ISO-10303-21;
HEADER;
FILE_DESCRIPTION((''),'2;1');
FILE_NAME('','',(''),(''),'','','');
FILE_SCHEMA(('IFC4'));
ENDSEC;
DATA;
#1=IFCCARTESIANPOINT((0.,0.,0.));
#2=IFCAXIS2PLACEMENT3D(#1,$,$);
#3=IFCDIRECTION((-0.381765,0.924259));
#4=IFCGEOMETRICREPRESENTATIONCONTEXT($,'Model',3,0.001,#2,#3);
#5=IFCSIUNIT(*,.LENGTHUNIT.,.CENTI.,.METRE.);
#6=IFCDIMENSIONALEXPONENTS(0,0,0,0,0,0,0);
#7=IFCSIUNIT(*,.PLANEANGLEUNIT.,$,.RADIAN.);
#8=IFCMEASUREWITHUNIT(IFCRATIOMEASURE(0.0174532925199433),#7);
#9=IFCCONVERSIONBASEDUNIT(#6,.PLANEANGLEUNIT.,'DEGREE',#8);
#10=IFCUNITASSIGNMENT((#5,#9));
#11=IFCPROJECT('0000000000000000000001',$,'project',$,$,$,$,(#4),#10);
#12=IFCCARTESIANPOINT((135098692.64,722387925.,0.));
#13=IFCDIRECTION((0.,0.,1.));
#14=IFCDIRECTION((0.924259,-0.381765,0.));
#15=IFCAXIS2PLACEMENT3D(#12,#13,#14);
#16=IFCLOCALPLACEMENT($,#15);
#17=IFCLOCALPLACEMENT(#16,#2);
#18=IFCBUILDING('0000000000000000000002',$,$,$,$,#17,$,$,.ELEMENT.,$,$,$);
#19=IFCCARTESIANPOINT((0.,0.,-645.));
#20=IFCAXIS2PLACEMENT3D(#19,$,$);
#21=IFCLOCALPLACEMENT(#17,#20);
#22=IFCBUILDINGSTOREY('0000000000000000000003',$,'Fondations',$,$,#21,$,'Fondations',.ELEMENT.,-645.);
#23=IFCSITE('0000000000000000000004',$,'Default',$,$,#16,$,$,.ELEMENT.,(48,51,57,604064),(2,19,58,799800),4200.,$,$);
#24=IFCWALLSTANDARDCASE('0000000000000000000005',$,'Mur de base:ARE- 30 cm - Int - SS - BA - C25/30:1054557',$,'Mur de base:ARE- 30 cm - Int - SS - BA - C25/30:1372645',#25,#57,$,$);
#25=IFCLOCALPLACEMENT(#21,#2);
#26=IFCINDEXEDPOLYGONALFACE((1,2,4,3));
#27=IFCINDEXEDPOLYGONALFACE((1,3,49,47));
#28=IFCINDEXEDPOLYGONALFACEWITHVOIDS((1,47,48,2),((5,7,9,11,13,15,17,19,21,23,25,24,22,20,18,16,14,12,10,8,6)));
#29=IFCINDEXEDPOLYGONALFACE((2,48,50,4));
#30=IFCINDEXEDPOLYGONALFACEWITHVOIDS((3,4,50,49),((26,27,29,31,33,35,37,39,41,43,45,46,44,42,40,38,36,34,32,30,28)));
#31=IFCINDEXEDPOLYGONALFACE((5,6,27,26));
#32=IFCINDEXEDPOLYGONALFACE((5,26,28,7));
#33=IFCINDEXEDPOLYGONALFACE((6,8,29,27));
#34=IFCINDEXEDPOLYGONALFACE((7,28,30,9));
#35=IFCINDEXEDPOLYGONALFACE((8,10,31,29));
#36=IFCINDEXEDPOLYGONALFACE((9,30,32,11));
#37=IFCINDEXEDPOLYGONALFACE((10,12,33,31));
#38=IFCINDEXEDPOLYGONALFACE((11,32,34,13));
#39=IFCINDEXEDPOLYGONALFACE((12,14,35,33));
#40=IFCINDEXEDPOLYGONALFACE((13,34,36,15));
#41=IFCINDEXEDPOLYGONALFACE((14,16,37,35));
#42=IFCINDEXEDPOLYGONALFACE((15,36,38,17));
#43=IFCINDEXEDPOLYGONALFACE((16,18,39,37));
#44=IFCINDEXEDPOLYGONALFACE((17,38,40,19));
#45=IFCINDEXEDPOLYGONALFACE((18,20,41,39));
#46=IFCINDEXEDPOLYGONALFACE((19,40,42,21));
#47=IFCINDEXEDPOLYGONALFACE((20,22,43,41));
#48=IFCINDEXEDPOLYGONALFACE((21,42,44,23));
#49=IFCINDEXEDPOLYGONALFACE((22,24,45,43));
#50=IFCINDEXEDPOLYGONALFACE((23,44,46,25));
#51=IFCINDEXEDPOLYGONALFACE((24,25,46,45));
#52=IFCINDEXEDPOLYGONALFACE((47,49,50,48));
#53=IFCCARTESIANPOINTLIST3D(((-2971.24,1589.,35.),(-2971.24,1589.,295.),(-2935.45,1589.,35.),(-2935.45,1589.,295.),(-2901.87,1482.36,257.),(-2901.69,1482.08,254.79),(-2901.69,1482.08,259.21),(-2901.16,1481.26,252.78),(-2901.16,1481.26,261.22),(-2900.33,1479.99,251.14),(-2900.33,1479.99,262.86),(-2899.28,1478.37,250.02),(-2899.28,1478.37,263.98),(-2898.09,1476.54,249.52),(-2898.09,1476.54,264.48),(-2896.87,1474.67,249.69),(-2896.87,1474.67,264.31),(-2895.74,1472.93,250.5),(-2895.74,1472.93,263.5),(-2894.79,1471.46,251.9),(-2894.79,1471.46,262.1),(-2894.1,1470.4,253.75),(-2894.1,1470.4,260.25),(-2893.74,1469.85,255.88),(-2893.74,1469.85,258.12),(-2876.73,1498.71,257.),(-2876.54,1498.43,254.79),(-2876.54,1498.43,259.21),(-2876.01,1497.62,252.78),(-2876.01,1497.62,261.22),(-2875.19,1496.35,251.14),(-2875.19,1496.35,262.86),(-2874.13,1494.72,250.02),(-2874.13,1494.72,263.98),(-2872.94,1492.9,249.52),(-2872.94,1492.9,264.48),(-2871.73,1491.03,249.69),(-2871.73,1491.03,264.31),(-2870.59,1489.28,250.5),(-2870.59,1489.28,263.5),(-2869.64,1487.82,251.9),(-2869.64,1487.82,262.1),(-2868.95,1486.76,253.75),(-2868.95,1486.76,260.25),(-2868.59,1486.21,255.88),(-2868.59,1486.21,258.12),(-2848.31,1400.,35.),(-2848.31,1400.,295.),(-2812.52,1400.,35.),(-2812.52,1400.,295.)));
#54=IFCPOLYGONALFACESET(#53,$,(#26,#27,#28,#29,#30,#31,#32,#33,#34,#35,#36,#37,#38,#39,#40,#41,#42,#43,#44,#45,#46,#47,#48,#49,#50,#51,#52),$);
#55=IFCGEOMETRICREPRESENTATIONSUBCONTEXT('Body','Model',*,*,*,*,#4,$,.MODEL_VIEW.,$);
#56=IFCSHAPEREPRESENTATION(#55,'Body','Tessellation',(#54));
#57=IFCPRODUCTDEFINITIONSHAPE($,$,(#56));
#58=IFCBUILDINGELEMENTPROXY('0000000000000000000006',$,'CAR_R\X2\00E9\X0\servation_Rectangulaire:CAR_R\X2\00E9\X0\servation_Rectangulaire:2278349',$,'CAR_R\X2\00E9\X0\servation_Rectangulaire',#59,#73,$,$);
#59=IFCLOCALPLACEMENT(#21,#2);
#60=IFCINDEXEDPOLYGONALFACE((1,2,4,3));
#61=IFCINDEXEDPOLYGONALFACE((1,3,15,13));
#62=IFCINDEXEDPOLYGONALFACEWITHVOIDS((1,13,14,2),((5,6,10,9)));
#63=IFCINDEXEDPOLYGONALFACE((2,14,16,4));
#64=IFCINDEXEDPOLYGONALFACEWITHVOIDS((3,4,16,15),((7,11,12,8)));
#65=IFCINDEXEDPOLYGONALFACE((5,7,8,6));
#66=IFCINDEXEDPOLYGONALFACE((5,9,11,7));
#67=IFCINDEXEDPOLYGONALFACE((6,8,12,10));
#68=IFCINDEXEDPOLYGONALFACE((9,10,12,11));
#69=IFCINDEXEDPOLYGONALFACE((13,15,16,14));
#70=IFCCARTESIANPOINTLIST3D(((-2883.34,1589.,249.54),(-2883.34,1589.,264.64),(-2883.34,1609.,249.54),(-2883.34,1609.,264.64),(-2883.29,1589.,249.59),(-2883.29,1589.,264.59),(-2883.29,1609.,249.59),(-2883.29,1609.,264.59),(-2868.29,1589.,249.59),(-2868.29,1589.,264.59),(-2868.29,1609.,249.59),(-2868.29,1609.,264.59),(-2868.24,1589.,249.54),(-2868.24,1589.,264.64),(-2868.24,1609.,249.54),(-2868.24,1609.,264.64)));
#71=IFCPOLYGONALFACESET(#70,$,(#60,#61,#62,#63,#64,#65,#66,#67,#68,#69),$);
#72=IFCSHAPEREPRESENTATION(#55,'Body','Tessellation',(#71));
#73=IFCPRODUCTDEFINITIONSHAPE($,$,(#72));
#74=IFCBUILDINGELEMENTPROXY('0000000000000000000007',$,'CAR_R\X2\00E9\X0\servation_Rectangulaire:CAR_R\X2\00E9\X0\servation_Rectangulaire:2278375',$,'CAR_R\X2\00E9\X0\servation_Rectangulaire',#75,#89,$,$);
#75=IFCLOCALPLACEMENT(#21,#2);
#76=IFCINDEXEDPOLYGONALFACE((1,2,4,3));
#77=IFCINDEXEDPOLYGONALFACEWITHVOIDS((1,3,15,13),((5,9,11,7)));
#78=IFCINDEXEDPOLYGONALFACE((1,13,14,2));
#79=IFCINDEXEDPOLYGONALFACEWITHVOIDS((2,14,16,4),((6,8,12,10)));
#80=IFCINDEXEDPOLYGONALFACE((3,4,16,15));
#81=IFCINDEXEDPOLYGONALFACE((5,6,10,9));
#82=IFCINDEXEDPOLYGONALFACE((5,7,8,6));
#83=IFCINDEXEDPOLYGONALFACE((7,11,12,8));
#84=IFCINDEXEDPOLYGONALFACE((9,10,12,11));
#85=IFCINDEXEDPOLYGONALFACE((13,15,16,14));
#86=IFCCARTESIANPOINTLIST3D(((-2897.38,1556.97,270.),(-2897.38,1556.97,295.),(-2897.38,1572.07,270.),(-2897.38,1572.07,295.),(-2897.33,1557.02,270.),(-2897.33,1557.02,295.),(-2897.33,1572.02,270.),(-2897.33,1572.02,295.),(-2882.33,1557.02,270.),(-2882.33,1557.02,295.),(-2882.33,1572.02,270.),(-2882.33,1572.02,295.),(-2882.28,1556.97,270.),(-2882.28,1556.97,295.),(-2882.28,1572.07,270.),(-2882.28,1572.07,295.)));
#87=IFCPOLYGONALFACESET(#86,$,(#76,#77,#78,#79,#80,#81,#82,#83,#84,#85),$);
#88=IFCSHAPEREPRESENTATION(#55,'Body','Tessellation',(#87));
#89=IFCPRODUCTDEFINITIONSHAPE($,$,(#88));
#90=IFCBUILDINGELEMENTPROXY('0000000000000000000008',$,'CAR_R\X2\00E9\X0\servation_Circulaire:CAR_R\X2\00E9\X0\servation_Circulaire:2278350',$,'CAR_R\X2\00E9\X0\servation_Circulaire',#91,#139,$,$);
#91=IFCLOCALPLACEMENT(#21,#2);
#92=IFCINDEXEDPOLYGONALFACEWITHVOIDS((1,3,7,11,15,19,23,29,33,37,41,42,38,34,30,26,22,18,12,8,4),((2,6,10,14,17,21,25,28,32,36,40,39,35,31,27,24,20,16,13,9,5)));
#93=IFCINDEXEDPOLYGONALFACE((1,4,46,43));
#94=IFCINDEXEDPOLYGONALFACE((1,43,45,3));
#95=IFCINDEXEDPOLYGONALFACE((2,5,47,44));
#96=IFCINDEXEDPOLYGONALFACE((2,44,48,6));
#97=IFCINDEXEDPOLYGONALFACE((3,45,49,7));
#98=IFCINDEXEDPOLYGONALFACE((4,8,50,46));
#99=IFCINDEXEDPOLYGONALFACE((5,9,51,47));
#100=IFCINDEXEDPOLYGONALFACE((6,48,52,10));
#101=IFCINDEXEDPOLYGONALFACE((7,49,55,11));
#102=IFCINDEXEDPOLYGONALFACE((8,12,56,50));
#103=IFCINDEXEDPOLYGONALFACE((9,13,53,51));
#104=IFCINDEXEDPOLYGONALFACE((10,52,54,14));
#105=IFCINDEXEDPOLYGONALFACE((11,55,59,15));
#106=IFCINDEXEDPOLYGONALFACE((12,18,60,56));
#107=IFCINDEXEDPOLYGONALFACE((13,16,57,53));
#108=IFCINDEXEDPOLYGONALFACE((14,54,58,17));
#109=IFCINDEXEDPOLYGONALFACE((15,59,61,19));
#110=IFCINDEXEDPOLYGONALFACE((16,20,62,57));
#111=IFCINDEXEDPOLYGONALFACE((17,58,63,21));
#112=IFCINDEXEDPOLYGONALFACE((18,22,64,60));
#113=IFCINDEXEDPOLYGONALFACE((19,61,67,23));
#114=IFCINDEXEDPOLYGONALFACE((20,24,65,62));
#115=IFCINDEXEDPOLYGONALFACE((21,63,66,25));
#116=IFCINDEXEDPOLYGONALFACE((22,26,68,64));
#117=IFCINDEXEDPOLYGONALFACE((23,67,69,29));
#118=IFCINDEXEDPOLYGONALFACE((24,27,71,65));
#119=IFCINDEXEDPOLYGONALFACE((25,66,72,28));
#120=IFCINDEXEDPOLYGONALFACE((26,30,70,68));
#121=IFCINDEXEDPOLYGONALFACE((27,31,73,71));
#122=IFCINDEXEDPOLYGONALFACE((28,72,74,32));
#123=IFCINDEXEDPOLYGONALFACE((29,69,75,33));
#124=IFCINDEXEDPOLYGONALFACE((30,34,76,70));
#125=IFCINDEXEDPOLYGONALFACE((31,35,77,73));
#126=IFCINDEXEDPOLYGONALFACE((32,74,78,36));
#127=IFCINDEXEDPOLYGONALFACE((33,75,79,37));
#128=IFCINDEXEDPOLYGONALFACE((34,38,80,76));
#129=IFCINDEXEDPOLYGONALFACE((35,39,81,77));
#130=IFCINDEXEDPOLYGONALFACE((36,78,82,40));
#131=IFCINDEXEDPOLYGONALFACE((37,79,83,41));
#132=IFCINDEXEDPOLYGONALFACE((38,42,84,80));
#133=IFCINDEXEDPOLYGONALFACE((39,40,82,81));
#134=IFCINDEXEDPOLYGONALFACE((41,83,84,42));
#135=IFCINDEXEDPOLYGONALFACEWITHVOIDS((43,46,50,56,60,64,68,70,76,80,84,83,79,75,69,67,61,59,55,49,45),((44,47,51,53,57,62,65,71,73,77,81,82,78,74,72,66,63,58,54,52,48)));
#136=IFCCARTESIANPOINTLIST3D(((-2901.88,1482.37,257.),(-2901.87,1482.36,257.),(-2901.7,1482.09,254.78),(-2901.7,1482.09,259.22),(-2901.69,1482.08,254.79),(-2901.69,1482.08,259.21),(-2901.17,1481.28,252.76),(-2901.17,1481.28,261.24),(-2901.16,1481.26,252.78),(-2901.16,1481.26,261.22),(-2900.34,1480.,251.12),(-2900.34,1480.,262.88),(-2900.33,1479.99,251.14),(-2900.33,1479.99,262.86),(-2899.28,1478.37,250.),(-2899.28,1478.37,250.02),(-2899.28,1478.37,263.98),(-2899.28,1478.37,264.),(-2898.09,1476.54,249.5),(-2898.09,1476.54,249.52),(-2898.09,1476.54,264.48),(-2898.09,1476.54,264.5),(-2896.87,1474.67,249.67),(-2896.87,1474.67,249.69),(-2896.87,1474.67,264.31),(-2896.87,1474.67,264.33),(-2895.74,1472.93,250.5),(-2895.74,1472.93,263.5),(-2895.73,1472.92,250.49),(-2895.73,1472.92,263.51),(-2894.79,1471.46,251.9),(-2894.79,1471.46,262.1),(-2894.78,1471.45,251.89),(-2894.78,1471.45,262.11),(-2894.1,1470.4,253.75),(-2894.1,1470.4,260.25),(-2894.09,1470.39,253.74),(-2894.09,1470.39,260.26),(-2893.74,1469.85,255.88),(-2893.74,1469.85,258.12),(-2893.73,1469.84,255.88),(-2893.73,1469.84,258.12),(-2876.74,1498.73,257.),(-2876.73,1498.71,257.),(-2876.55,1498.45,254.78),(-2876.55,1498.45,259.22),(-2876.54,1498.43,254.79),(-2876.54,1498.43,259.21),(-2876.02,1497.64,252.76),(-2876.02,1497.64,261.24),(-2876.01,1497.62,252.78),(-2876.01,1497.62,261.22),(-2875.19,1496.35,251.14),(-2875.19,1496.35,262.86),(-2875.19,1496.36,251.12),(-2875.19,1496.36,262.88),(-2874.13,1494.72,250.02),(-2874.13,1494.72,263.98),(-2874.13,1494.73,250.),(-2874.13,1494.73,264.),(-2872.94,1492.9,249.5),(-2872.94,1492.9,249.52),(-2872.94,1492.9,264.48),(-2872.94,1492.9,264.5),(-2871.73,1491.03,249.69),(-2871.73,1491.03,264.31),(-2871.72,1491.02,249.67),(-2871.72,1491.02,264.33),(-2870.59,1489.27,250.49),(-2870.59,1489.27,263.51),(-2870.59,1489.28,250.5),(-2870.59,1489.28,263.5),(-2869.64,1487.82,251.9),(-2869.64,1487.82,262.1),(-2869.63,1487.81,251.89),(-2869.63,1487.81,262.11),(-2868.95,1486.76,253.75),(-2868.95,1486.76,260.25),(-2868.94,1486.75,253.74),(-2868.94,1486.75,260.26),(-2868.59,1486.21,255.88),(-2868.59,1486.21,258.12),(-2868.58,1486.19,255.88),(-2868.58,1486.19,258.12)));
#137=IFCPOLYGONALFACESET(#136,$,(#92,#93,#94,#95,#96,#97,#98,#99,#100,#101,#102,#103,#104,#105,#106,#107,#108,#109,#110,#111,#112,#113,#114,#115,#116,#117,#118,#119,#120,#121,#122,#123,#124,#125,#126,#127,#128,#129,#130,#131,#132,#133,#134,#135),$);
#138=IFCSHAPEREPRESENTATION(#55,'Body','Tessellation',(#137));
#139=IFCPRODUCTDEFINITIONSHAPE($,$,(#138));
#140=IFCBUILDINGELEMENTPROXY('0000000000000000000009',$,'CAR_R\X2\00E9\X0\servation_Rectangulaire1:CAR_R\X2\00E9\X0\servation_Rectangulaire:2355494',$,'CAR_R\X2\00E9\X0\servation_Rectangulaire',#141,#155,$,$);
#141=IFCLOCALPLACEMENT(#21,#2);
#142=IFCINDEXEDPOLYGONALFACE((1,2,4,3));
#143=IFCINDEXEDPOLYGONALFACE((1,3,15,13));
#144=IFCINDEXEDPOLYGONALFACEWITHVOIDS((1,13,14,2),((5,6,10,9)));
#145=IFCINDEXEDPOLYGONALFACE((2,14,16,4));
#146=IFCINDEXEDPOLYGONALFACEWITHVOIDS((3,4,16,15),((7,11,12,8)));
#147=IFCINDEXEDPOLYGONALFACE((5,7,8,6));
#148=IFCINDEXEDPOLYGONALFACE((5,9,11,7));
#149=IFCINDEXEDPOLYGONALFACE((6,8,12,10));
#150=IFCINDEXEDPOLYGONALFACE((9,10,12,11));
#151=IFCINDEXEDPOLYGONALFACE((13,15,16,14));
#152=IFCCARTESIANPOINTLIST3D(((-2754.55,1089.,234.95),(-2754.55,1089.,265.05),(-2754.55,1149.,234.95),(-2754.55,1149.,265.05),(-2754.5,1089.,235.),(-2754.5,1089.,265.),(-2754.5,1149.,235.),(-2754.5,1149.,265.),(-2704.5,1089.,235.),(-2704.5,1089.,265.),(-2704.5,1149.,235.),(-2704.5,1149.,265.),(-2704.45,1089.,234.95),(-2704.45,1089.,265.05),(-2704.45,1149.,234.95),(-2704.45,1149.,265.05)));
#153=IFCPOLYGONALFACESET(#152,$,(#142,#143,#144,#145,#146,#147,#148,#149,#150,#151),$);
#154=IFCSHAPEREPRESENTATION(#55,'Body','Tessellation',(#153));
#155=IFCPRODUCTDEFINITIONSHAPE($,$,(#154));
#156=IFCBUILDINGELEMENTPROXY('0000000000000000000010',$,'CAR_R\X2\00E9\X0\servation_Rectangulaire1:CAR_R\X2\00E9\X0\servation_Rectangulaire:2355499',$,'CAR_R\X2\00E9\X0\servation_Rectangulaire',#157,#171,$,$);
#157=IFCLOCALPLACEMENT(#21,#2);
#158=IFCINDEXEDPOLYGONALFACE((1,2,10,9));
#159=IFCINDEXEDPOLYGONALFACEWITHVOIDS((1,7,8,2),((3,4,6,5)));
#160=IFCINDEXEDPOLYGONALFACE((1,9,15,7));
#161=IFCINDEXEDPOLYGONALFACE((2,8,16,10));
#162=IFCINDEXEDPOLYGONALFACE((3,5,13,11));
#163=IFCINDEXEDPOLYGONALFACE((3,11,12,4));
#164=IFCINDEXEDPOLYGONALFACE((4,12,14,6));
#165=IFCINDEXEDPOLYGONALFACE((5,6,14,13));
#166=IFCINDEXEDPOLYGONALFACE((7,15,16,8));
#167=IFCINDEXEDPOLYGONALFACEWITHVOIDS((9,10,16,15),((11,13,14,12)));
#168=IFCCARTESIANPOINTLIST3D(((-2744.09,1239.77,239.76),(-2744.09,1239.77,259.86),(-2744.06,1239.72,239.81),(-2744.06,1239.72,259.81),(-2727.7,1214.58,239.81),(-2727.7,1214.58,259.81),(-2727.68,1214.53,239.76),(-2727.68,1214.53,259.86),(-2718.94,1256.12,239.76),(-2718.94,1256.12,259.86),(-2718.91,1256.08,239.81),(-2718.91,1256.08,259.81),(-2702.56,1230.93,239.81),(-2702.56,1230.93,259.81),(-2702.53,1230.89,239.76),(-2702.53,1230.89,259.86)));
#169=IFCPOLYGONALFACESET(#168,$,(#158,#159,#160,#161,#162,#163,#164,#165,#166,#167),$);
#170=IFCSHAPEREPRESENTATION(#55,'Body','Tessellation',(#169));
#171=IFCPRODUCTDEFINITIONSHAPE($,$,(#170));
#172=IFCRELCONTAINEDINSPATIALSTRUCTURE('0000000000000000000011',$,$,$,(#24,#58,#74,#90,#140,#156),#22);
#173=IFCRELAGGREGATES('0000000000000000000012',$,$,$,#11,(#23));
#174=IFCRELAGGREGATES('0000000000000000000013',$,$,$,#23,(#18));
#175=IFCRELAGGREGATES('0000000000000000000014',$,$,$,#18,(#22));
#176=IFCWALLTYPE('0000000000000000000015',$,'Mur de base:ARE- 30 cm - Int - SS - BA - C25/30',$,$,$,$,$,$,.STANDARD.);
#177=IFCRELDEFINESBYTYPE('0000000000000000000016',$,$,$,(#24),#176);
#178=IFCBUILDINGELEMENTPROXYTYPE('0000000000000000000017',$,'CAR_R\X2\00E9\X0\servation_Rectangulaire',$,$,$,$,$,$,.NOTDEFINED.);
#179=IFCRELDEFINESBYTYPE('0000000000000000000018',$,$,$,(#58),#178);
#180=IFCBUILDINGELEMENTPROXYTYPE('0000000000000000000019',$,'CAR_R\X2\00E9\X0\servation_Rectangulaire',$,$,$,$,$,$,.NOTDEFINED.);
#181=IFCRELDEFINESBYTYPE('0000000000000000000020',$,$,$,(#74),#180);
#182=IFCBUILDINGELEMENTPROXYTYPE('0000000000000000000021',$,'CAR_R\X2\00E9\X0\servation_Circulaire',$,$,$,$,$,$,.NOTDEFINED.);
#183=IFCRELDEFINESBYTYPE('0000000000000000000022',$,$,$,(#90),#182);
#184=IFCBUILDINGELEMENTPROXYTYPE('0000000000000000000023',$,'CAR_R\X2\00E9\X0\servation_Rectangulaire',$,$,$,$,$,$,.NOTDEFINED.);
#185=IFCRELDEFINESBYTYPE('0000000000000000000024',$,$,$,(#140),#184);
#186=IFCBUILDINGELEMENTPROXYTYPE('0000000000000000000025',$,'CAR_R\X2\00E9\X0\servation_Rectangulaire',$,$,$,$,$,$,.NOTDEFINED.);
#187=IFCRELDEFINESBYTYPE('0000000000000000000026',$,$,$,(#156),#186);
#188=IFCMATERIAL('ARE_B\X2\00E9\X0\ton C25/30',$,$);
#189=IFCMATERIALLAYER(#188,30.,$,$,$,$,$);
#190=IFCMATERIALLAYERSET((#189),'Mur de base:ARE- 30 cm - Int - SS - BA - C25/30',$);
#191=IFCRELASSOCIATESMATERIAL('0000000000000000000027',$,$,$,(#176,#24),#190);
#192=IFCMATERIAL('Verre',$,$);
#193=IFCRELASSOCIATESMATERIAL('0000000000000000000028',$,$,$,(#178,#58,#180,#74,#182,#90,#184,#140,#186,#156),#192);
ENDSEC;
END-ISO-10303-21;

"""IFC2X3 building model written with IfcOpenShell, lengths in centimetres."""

from ifc_helpers import new_model, entity, si_unit, converted_unit, direction, frame, frame_2d, origin, place, context, subcontext, project, spatial, polyline, circle, hollow_circle, outline, extrude, source, transform, mapped, material, layer, layer_set, layer_usage, type_object, type_shapes, element, save


model = new_model("IFC2X3")

# Units and contexts
model_context = context("Model", 3, precision=0.001, world=origin(), true_north=direction((-0.381765, 0.924259)))
body_context = subcontext(model_context, "Body", "Model", "MODEL_VIEW")
ifc_project = project(units=[si_unit("LENGTHUNIT", "METRE", prefix="CENTI"), converted_unit("PLANEANGLEUNIT", "DEGREE", entity("IfcRatioMeasure", 0.0174532925199433), si_unit("PLANEANGLEUNIT", "RADIAN"), dimensions=[0, 0, 0, 0, 0, 0, 0])], contexts=[model_context])

# Site, building, storey
site_placement = place(None, frame((135098692.64, 722387925.0, 0.0), z_axis=(0.0, 0.0, 1.0), x_axis=(0.924259, -0.381765, 0.0)))
site = spatial("IfcSite", under=ifc_project, at=site_placement, Name="Default", CompositionType="ELEMENT", RefLatitude=(48, 51, 57, 604064), RefLongitude=(2, 19, 58, 799800), RefElevation=4200.0)
building_placement = place(site_placement, origin())
building = spatial("IfcBuilding", under=site, at=building_placement, CompositionType="ELEMENT")
storey_placement = place(building_placement, frame((0.0, 0.0, -645.0)))
storey = spatial("IfcBuildingStorey", under=building, at=storey_placement, Name="Fondations", LongName="Fondations", CompositionType="ELEMENT", Elevation=-645.0)

# Shared definitions
ifc_material_1 = material(Name="ARE_Béton C25/30")

# Wall, opening
ifc_layer_1 = layer(ifc_material_1, 30.0)
ifc_layer_set_1 = layer_set([ifc_layer_1], Name="Mur de base:ARE- 30 cm - Int - SS - BA - C25/30")
ifc_layer_usage_1 = layer_usage(ifc_layer_set_1, "AXIS2", "NEGATIVE", 15.0)
wall_type_1 = type_object("IfcWallType", Name="Mur de base:ARE- 30 cm - Int - SS - BA - C25/30", PredefinedType="STANDARD", material=ifc_layer_set_1)
wall_1_placement = place(storey_placement, frame((-2825.09, 1391.82, 35.0), z_axis=(0.0, 0.0, 1.0), x_axis=(-0.545236, 0.838282, 0.0)))
wall_1 = element("IfcWallStandardCase", 1, at=wall_1_placement, inside=storey, type_object=wall_type_1, material=ifc_layer_usage_1, Name="Mur de base:ARE- 30 cm - Int - SS - BA - C25/30:1054557", ObjectType="Mur de base:ARE- 30 cm - Int - SS - BA - C25/30:1372645", context=body_context, shape_type="SweptSolid", body=[
    extrude(outline(polyline([(225.46, -15.0), (244.97, 15.0), (19.51, 15.0), (0.0, -15.0), (225.46, -15.0)])), origin(), (0.0, 0.0, 1.0), 260.0),
])
opening_1_placement = place(wall_1_placement, origin())
element("IfcOpeningElement", 2, at=opening_1_placement, cuts=wall_1, ObjectType="Opening", context=body_context, shape_type="SweptSolid", body=[
    extrude(circle(Radius=7.5, at=frame_2d((0.0, 0.0), x_axis=(1.0, 0.0))), frame((110.26, -15.0, 222.0), z_axis=(0.0, 1.0, 0.0), x_axis=(1.0, 0.0, 0.0)), (0.0, 0.0, 1.0), 30.0),
])

# Building element proxies
ifc_material_2 = material(Name="Verre")
building_element_proxy_type_1 = type_object("IfcBuildingElementProxyType", Name="CAR_Réservation_Rectangulaire", PredefinedType="NOTDEFINED", material=ifc_material_2)
shared_shape_1 = source(origin(), body_context, "Body", "SweptSolid", [
    extrude(outline(polyline([(-7.55, -7.55), (7.55, -7.55), (7.55, 7.55), (-7.55, 7.55), (-7.55, -7.55)]), holes=[polyline([(7.5, -7.5), (-7.5, -7.5), (-7.5, 7.5), (7.5, 7.5), (7.5, -7.5)])]), frame((0.0, 0.0, -20.0), z_axis=(0.0, 0.0, 1.0), x_axis=(-1.0, 0.0, 0.0)), (0.0, 0.0, 1.0), 20.0),
])
type_shapes(building_element_proxy_type_1, [shared_shape_1])
proxy_1_placement = place(storey_placement, frame((-2875.79, 1609.0, 257.09), z_axis=(0.0, 1.0, 0.0), x_axis=(1.0, 0.0, 0.0)))
element("IfcBuildingElementProxy", 3, at=proxy_1_placement, inside=storey, type_object=building_element_proxy_type_1, material=ifc_material_2, Name="CAR_Réservation_Rectangulaire:CAR_Réservation_Rectangulaire:2278349", ObjectType="CAR_Réservation_Rectangulaire", context=body_context, shape_type="MappedRepresentation", body=[
    mapped(shared_shape_1, transform((0.0, 0.0, 0.0), scale=1.0)),
])
building_element_proxy_type_2 = type_object("IfcBuildingElementProxyType", Name="CAR_Réservation_Rectangulaire", PredefinedType="NOTDEFINED", material=ifc_material_2)
shared_shape_2 = source(origin(), body_context, "Body", "SweptSolid", [
    extrude(outline(polyline([(-7.55, -7.55), (7.55, -7.55), (7.55, 7.55), (-7.55, 7.55), (-7.55, -7.55)]), holes=[polyline([(7.5, -7.5), (-7.5, -7.5), (-7.5, 7.5), (7.5, 7.5), (7.5, -7.5)])]), frame((0.0, 0.0, -25.0), z_axis=(0.0, 0.0, 1.0), x_axis=(-1.0, 0.0, 0.0)), (0.0, 0.0, 1.0), 25.0),
])
type_shapes(building_element_proxy_type_2, [shared_shape_2])
proxy_2_placement = place(storey_placement, frame((-2889.83, 1564.52, 295.0)))
element("IfcBuildingElementProxy", 4, at=proxy_2_placement, inside=storey, type_object=building_element_proxy_type_2, material=ifc_material_2, Name="CAR_Réservation_Rectangulaire:CAR_Réservation_Rectangulaire:2278375", ObjectType="CAR_Réservation_Rectangulaire", context=body_context, shape_type="MappedRepresentation", body=[
    mapped(shared_shape_2, transform((0.0, 0.0, 0.0), scale=1.0)),
])
building_element_proxy_type_3 = type_object("IfcBuildingElementProxyType", Name="CAR_Réservation_Circulaire", PredefinedType="NOTDEFINED", material=ifc_material_2)
shared_shape_3 = source(origin(), body_context, "Body", "SweptSolid", [
    extrude(hollow_circle(Radius=7.52, WallThickness=0.02, at=frame_2d((0.0, 0.0), x_axis=(1.0, 0.0))), frame((0.0, 0.0, -30.0)), (0.0, 0.0, 1.0), 30.0),
])
type_shapes(building_element_proxy_type_3, [shared_shape_3])
proxy_3_placement = place(storey_placement, frame((-2872.64, 1492.43, 257.0), z_axis=(0.838282, 0.545236, 0.0), x_axis=(-0.545236, 0.838282, 0.0)))
element("IfcBuildingElementProxy", 5, at=proxy_3_placement, inside=storey, type_object=building_element_proxy_type_3, material=ifc_material_2, Name="CAR_Réservation_Circulaire:CAR_Réservation_Circulaire:2278350", ObjectType="CAR_Réservation_Circulaire", context=body_context, shape_type="MappedRepresentation", body=[
    mapped(shared_shape_3, transform((0.0, 0.0, 0.0), scale=1.0)),
])
building_element_proxy_type_4 = type_object("IfcBuildingElementProxyType", Name="CAR_Réservation_Rectangulaire", PredefinedType="NOTDEFINED", material=ifc_material_2)
shared_shape_4 = source(origin(), body_context, "Body", "SweptSolid", [
    extrude(outline(polyline([(-25.05, -15.05), (25.05, -15.05), (25.05, 15.05), (-25.05, 15.05), (-25.05, -15.05)]), holes=[polyline([(25.0, -15.0), (-25.0, -15.0), (-25.0, 15.0), (25.0, 15.0), (25.0, -15.0)])]), frame((0.0, 0.0, -60.0), z_axis=(0.0, 0.0, 1.0), x_axis=(-1.0, 0.0, 0.0)), (0.0, 0.0, 1.0), 60.0),
])
type_shapes(building_element_proxy_type_4, [shared_shape_4])
proxy_4_placement = place(storey_placement, frame((-2729.5, 1089.0, 250.0), z_axis=(0.0, -1.0, 0.0), x_axis=(1.0, 0.0, 0.0)))
element("IfcBuildingElementProxy", 6, at=proxy_4_placement, inside=storey, type_object=building_element_proxy_type_4, material=ifc_material_2, Name="CAR_Réservation_Rectangulaire1:CAR_Réservation_Rectangulaire:2355494", ObjectType="CAR_Réservation_Rectangulaire", context=body_context, shape_type="MappedRepresentation", body=[
    mapped(shared_shape_4, transform((0.0, 0.0, 0.0), scale=1.0)),
])
building_element_proxy_type_5 = type_object("IfcBuildingElementProxyType", Name="CAR_Réservation_Rectangulaire", PredefinedType="NOTDEFINED", material=ifc_material_2)
shared_shape_5 = source(origin(), body_context, "Body", "SweptSolid", [
    extrude(outline(polyline([(-15.05, -10.05), (15.05, -10.05), (15.05, 10.05), (-15.05, 10.05), (-15.05, -10.05)]), holes=[polyline([(15.0, -10.0), (-15.0, -10.0), (-15.0, 10.0), (15.0, 10.0), (15.0, -10.0)])]), frame((0.0, 0.0, -15.0), z_axis=(0.0, 0.0, 1.0), x_axis=(-1.0, 0.0, 0.0)), (0.0, 0.0, 1.0), 30.0),
])
type_shapes(building_element_proxy_type_5, [shared_shape_5])
proxy_5_placement = place(storey_placement, frame((-2723.31, 1235.33, 249.81), z_axis=(0.838282, 0.545236, 0.0), x_axis=(-0.545236, 0.838282, 0.0)))
element("IfcBuildingElementProxy", 7, at=proxy_5_placement, inside=storey, type_object=building_element_proxy_type_5, material=ifc_material_2, Name="CAR_Réservation_Rectangulaire1:CAR_Réservation_Rectangulaire:2355499", ObjectType="CAR_Réservation_Rectangulaire", context=body_context, shape_type="MappedRepresentation", body=[
    mapped(shared_shape_5, transform((0.0, 0.0, 0.0), scale=1.0)),
])

save(model, "model.ifc")
